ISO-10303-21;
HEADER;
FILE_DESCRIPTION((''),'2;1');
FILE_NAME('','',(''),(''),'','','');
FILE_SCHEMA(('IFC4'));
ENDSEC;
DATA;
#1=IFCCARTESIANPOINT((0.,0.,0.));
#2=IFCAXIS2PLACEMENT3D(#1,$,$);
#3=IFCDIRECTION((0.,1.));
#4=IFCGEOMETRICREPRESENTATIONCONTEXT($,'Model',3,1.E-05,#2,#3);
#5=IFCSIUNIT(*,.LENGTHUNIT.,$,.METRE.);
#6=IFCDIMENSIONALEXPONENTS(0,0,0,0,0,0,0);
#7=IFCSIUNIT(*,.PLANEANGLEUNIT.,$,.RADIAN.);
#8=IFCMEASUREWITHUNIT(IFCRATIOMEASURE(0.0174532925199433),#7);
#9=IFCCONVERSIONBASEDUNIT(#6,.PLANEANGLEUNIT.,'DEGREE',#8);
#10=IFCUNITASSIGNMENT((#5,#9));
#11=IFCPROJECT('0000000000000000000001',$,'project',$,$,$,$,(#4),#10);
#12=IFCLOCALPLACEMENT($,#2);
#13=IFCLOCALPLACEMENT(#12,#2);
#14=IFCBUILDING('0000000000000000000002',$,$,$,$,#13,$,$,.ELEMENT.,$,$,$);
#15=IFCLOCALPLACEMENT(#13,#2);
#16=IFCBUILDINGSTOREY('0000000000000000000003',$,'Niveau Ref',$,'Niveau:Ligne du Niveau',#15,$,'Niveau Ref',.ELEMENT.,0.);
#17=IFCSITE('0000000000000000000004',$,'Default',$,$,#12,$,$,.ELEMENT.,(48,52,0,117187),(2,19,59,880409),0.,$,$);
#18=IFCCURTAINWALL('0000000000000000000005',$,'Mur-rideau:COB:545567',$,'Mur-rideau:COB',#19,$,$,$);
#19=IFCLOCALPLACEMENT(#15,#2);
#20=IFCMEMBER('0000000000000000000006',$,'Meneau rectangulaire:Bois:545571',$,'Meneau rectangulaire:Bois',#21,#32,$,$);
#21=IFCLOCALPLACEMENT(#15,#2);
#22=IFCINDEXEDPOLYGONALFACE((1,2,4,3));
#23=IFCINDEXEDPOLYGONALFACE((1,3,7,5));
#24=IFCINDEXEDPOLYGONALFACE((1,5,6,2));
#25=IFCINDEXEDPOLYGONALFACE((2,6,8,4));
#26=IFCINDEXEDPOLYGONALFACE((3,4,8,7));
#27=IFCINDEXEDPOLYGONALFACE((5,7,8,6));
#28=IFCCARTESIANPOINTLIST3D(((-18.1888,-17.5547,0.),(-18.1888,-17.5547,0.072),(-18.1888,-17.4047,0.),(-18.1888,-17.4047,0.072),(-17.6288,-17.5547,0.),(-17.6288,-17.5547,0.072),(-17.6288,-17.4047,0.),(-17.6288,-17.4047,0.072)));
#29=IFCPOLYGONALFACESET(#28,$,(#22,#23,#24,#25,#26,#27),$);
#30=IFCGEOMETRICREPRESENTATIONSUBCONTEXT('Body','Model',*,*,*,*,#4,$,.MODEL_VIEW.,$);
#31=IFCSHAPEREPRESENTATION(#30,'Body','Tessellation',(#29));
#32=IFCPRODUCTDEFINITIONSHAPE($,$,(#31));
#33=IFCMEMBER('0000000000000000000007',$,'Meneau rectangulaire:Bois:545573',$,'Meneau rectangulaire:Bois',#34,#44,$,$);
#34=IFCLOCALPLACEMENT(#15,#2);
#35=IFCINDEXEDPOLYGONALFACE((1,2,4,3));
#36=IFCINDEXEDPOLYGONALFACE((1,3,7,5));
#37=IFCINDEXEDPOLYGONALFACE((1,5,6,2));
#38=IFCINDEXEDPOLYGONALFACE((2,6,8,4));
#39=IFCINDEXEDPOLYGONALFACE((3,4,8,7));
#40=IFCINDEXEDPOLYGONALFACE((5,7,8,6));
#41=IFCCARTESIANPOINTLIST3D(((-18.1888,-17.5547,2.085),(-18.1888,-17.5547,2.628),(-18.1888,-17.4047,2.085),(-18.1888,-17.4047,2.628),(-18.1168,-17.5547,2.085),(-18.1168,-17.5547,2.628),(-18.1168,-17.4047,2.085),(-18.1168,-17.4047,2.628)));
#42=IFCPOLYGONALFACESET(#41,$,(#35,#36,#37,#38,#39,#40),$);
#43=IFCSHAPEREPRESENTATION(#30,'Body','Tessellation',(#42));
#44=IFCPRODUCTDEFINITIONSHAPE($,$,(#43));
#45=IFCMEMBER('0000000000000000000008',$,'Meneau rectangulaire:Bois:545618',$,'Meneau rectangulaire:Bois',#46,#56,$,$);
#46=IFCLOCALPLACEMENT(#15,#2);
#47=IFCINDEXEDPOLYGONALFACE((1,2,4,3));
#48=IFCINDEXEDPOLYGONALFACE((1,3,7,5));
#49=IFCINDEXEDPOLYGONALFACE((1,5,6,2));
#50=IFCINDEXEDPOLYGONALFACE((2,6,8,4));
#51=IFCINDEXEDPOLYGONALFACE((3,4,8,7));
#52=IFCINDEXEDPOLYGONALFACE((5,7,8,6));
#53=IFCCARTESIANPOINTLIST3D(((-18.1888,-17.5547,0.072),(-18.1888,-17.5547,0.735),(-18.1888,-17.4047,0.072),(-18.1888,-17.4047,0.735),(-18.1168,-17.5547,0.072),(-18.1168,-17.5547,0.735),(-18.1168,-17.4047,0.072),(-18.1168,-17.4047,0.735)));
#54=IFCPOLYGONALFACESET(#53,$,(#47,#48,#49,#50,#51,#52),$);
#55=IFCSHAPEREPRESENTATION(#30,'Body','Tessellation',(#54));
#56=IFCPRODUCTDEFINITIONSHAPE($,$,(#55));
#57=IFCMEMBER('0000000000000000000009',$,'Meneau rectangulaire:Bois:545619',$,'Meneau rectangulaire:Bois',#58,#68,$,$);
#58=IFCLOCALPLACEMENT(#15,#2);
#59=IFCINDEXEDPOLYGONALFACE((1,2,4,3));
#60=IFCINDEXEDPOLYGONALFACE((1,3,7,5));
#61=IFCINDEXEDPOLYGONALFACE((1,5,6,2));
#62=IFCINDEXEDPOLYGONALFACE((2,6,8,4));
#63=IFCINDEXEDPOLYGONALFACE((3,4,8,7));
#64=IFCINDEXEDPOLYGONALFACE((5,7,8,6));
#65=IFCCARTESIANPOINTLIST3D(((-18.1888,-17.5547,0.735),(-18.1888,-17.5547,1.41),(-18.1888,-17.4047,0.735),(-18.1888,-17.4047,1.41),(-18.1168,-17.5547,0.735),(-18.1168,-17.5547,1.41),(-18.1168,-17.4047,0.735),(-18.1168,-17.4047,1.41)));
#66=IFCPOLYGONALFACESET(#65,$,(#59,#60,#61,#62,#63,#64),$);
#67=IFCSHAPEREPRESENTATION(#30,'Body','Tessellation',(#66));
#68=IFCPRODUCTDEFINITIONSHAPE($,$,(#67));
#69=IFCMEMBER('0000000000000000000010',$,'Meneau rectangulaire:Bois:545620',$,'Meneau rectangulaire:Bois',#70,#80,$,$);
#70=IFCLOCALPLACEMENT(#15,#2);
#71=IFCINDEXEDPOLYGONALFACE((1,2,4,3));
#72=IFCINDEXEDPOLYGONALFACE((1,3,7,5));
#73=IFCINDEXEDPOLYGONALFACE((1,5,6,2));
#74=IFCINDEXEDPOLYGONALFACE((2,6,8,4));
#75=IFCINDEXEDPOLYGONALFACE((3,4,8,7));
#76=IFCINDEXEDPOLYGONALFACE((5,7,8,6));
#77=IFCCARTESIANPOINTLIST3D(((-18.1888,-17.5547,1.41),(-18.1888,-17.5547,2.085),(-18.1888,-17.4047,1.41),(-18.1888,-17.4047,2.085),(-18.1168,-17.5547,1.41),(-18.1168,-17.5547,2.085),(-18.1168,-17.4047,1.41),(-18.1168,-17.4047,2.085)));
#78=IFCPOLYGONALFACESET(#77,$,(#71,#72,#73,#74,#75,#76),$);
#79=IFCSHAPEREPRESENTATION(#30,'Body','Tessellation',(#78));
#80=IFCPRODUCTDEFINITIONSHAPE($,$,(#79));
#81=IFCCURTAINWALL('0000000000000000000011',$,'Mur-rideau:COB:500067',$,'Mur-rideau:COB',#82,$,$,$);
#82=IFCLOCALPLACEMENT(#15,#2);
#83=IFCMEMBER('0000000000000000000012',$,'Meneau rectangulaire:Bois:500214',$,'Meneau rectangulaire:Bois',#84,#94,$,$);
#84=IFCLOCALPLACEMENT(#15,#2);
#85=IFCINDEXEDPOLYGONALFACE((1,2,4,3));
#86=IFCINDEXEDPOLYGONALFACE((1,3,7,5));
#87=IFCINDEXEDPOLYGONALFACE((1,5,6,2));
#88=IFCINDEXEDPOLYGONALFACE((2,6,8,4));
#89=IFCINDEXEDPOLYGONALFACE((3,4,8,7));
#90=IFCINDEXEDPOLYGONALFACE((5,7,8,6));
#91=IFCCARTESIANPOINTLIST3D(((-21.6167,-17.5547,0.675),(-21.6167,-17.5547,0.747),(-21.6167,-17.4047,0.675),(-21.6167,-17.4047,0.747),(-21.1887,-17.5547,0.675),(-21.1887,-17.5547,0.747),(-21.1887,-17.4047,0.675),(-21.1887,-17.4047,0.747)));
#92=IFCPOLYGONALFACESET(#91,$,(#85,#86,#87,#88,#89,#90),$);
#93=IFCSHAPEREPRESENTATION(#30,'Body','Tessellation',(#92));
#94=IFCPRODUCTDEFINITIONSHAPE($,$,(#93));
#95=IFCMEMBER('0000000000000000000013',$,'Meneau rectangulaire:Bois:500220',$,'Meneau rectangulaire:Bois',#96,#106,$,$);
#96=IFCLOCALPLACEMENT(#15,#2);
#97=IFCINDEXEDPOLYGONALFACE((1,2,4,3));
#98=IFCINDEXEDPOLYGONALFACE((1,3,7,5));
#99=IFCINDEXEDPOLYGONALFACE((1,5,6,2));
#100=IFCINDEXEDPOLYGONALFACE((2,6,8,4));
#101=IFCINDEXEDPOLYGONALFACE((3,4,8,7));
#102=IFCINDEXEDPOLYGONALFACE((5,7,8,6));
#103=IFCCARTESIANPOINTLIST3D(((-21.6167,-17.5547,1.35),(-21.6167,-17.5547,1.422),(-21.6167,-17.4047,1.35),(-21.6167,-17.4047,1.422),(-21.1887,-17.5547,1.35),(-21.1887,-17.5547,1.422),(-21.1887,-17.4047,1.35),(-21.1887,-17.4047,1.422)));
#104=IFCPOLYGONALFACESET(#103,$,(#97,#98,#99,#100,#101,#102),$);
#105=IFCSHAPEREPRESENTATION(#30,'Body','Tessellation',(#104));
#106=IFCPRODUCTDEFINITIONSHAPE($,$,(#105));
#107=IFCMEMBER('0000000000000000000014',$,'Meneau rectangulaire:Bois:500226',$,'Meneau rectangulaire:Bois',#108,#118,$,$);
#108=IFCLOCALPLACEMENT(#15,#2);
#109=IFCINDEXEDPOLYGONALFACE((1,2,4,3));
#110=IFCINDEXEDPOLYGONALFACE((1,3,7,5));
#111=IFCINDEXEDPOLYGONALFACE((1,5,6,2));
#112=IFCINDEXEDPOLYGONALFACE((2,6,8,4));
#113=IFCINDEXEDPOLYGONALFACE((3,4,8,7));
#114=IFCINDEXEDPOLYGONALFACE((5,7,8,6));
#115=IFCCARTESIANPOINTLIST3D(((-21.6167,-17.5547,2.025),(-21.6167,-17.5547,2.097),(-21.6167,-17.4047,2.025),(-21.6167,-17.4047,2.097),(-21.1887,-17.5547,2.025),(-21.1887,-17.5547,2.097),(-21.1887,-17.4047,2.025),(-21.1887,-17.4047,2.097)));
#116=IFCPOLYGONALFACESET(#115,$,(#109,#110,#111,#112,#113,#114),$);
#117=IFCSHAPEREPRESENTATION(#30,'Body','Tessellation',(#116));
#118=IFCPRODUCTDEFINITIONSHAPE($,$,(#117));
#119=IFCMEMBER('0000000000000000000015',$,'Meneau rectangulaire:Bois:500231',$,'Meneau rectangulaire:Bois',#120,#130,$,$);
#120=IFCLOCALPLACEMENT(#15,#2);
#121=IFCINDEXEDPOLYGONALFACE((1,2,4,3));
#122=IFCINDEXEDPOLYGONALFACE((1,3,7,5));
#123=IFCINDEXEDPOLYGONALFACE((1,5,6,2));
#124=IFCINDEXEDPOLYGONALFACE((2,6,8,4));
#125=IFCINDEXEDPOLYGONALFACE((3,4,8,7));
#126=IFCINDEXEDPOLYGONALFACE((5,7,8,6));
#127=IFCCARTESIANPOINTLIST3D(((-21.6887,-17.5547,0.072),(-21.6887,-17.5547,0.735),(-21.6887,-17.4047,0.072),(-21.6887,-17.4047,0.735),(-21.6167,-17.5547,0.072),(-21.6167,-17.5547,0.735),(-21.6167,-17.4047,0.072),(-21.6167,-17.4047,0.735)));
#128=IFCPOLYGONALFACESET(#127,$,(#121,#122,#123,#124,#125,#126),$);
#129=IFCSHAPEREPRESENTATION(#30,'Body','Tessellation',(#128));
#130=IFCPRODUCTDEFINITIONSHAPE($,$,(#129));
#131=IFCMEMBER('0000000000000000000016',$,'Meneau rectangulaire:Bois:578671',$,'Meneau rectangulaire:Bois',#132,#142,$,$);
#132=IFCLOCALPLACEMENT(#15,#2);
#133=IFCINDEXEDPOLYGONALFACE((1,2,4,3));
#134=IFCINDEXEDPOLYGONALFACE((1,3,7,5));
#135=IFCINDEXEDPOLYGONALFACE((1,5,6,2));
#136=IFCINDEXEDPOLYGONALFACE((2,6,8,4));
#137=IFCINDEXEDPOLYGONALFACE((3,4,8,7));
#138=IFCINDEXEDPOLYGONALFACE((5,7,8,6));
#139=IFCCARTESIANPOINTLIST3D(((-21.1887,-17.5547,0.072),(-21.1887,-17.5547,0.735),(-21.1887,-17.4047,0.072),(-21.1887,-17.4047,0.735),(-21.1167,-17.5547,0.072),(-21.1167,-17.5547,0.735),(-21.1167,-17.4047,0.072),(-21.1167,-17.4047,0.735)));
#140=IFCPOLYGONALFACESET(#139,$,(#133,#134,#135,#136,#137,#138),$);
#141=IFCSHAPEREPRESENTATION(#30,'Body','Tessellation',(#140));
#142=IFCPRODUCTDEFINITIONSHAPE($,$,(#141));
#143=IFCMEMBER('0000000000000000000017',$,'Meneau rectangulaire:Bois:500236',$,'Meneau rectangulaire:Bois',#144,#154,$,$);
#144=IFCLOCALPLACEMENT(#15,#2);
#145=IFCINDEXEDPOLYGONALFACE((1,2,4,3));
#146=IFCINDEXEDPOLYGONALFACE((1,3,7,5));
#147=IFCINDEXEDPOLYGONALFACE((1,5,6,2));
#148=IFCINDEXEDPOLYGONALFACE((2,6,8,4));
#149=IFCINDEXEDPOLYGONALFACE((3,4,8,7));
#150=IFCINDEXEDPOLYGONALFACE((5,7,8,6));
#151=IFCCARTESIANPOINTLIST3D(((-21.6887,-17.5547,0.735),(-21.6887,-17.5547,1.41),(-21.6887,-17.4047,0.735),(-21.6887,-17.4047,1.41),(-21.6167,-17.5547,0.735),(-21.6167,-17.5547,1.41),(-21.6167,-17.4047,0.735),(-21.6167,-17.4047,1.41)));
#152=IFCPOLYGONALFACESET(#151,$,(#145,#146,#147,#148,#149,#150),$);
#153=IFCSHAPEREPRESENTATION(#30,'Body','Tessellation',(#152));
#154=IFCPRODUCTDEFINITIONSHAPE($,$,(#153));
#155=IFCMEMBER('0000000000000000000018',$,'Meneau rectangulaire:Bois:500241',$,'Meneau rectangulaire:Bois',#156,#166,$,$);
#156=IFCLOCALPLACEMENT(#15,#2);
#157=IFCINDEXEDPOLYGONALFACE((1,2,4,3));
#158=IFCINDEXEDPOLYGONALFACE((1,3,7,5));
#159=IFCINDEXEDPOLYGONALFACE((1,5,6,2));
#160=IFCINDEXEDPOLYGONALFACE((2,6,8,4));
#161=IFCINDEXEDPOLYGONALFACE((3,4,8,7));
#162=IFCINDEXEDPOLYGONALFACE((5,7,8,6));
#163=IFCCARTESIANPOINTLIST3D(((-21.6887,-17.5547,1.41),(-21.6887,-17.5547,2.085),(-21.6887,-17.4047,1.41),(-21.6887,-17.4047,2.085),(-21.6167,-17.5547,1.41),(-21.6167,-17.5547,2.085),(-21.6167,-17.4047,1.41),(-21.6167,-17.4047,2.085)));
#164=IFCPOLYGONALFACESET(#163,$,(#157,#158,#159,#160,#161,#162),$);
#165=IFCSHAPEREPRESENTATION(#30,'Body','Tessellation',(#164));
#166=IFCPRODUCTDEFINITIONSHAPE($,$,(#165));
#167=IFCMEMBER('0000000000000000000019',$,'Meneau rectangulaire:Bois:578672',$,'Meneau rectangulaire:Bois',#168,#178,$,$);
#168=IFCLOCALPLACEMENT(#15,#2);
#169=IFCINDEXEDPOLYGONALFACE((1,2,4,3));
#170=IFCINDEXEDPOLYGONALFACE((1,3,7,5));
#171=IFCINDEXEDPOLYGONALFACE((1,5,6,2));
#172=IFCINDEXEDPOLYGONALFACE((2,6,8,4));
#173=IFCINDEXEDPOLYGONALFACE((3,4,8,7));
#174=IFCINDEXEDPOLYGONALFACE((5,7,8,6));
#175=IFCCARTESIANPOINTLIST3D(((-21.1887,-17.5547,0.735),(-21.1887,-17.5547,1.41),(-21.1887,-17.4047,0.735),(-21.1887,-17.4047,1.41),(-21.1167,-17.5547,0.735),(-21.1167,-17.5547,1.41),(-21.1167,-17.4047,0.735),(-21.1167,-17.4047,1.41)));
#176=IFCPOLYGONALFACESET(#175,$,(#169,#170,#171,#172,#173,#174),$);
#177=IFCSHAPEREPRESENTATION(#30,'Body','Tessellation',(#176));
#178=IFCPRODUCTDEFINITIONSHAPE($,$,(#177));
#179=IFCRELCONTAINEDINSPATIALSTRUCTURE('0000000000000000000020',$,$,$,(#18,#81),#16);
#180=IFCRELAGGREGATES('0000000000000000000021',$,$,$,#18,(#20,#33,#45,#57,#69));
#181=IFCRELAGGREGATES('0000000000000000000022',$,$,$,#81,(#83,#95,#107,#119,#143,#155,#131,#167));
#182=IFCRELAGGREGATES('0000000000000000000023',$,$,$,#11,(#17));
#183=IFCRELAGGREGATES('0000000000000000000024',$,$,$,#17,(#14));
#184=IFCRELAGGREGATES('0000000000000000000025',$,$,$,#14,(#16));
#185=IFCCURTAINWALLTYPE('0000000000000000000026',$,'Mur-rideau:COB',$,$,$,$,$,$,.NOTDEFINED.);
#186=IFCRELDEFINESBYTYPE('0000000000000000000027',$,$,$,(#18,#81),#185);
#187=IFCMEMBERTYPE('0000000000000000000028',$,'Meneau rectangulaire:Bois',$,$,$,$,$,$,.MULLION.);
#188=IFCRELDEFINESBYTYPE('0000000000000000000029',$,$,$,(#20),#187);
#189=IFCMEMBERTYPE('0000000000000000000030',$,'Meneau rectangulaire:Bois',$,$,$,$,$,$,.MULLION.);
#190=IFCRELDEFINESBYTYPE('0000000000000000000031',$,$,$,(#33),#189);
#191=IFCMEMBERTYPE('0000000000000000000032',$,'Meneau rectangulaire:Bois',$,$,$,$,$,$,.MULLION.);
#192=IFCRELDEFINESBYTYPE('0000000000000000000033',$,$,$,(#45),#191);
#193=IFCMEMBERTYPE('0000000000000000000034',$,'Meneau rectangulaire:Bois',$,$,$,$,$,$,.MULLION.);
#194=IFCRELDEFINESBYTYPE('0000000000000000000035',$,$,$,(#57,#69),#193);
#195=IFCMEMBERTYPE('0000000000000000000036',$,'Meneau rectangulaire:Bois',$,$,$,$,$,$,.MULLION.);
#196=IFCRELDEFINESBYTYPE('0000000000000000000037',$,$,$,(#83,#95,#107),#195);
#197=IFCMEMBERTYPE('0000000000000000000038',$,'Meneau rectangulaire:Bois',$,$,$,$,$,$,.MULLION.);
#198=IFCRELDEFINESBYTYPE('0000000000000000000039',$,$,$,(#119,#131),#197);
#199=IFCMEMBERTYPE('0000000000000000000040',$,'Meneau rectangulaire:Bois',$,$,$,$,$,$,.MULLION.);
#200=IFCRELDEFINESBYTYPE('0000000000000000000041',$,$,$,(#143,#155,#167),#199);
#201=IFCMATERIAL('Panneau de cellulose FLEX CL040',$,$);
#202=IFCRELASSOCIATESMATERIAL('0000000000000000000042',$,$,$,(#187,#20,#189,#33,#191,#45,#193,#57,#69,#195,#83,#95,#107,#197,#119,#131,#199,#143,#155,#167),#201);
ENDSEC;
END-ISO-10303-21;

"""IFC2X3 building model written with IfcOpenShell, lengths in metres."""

from ifc_helpers import new_model, entity, si_unit, converted_unit, direction, frame, origin, origin_2d_with_axis, place, context, subcontext, project, spatial, rectangle, extrude, source, transform, mapped, material, type_object, type_shapes, element, aggregate, save


model = new_model("IFC2X3")

# Units and contexts
model_context = context("Model", 3, precision=1e-05, world=origin(), true_north=direction((0.0, 1.0)))
body_context = subcontext(model_context, "Body", "Model", "MODEL_VIEW")
ifc_project = project(units=[si_unit("LENGTHUNIT", "METRE"), converted_unit("PLANEANGLEUNIT", "DEGREE", entity("IfcRatioMeasure", 0.0174532925199433), si_unit("PLANEANGLEUNIT", "RADIAN"), dimensions=[0, 0, 0, 0, 0, 0, 0])], contexts=[model_context])

# Site, building, storey
site_placement = place(None, origin())
site = spatial("IfcSite", under=ifc_project, at=site_placement, Name="Default", CompositionType="ELEMENT", RefLatitude=(48, 52, 0, 117187), RefLongitude=(2, 19, 59, 880409), RefElevation=0.0)
building_placement = place(site_placement, origin())
building = spatial("IfcBuilding", under=site, at=building_placement, CompositionType="ELEMENT")
storey_placement = place(building_placement, origin())
storey = spatial("IfcBuildingStorey", under=building, at=storey_placement, Name="Niveau Ref", ObjectType="Niveau:Ligne du Niveau", LongName="Niveau Ref", CompositionType="ELEMENT", Elevation=0.0)

# Curtain walls, members
curtain_wall_type_1 = type_object("IfcCurtainWallType", Name="Mur-rideau:COB", PredefinedType="NOTDEFINED")
curtain_wall_1_placement = place(storey_placement, origin())
curtain_wall_1 = element("IfcCurtainWall", 1, at=curtain_wall_1_placement, inside=storey, type_object=curtain_wall_type_1, Name="Mur-rideau:COB:545567", ObjectType="Mur-rideau:COB")
ifc_material_1 = material(Name="Panneau de cellulose FLEX CL040")
member_type_1 = type_object("IfcMemberType", Name="Meneau rectangulaire:Bois", PredefinedType="MULLION", material=ifc_material_1)
shared_shape_1 = source(origin(), body_context, "Body", "SweptSolid", [
    extrude(rectangle(XDim=0.15, YDim=0.072, at=origin_2d_with_axis()), frame((-0.036, 0.0, -0.56), z_axis=(0.0, 0.0, 1.0), x_axis=(0.0, -1.0, 0.0)), (0.0, 0.0, 1.0), 0.56),
])
type_shapes(member_type_1, [shared_shape_1])
member_1_placement = place(storey_placement, frame((-18.1888, -17.4797, 0.0), z_axis=(-1.0, 0.0, 0.0), x_axis=(0.0, 0.0, -1.0)))
member_1 = element("IfcMember", 2, at=member_1_placement, type_object=member_type_1, material=ifc_material_1, Name="Meneau rectangulaire:Bois:545571", ObjectType="Meneau rectangulaire:Bois", context=body_context, shape_type="MappedRepresentation", body=[
    mapped(shared_shape_1, transform((0.0, 0.0, 0.0), scale=1.0)),
])
member_type_2 = type_object("IfcMemberType", Name="Meneau rectangulaire:Bois", PredefinedType="MULLION", material=ifc_material_1)
shared_shape_2 = source(origin(), body_context, "Body", "SweptSolid", [
    extrude(rectangle(XDim=0.15, YDim=0.072, at=origin_2d_with_axis()), frame((-0.036, 0.0, -0.543), z_axis=(0.0, 0.0, 1.0), x_axis=(0.0, -1.0, 0.0)), (0.0, 0.0, 1.0), 0.543),
])
type_shapes(member_type_2, [shared_shape_2])
member_2_placement = place(storey_placement, frame((-18.1888, -17.4797, 2.628), z_axis=(0.0, 0.0, 1.0), x_axis=(-1.0, 0.0, 0.0)))
member_2 = element("IfcMember", 3, at=member_2_placement, type_object=member_type_2, material=ifc_material_1, Name="Meneau rectangulaire:Bois:545573", ObjectType="Meneau rectangulaire:Bois", context=body_context, shape_type="MappedRepresentation", body=[
    mapped(shared_shape_2, transform((0.0, 0.0, 0.0), scale=1.0)),
])
member_type_3 = type_object("IfcMemberType", Name="Meneau rectangulaire:Bois", PredefinedType="MULLION", material=ifc_material_1)
shared_shape_3 = source(origin(), body_context, "Body", "SweptSolid", [
    extrude(rectangle(XDim=0.15, YDim=0.072, at=origin_2d_with_axis()), frame((-0.036, 0.0, -0.663), z_axis=(0.0, 0.0, 1.0), x_axis=(0.0, -1.0, 0.0)), (0.0, 0.0, 1.0), 0.663),
])
type_shapes(member_type_3, [shared_shape_3])
member_3_placement = place(storey_placement, frame((-18.1888, -17.4797, 0.735), z_axis=(0.0, 0.0, 1.0), x_axis=(-1.0, 0.0, 0.0)))
member_3 = element("IfcMember", 4, at=member_3_placement, type_object=member_type_3, material=ifc_material_1, Name="Meneau rectangulaire:Bois:545618", ObjectType="Meneau rectangulaire:Bois", context=body_context, shape_type="MappedRepresentation", body=[
    mapped(shared_shape_3, transform((0.0, 0.0, 0.0), scale=1.0)),
])
member_type_4 = type_object("IfcMemberType", Name="Meneau rectangulaire:Bois", PredefinedType="MULLION", material=ifc_material_1)
shared_shape_4 = source(origin(), body_context, "Body", "SweptSolid", [
    extrude(rectangle(XDim=0.15, YDim=0.072, at=origin_2d_with_axis()), frame((-0.036, 0.0, -0.675), z_axis=(0.0, 0.0, 1.0), x_axis=(0.0, -1.0, 0.0)), (0.0, 0.0, 1.0), 0.675),
])
type_shapes(member_type_4, [shared_shape_4])
member_4_placement = place(storey_placement, frame((-18.1888, -17.4797, 1.41), z_axis=(0.0, 0.0, 1.0), x_axis=(-1.0, 0.0, 0.0)))
member_4 = element("IfcMember", 5, at=member_4_placement, type_object=member_type_4, material=ifc_material_1, Name="Meneau rectangulaire:Bois:545619", ObjectType="Meneau rectangulaire:Bois", context=body_context, shape_type="MappedRepresentation", body=[
    mapped(shared_shape_4, transform((0.0, 0.0, 0.0), scale=1.0)),
])
member_5_placement = place(storey_placement, frame((-18.1888, -17.4797, 2.085), z_axis=(0.0, 0.0, 1.0), x_axis=(-1.0, 0.0, 0.0)))
member_5 = element("IfcMember", 6, at=member_5_placement, type_object=member_type_4, material=ifc_material_1, Name="Meneau rectangulaire:Bois:545620", ObjectType="Meneau rectangulaire:Bois", context=body_context, shape_type="MappedRepresentation", body=[
    mapped(shared_shape_4, transform((0.0, 0.0, 0.0), scale=1.0)),
])
aggregate(curtain_wall_1, [member_1, member_2, member_3, member_4, member_5])
curtain_wall_2_placement = place(storey_placement, origin())
curtain_wall_2 = element("IfcCurtainWall", 7, at=curtain_wall_2_placement, inside=storey, type_object=curtain_wall_type_1, Name="Mur-rideau:COB:500067", ObjectType="Mur-rideau:COB")
member_type_5 = type_object("IfcMemberType", Name="Meneau rectangulaire:Bois", PredefinedType="MULLION", material=ifc_material_1)
shared_shape_5 = source(origin(), body_context, "Body", "SweptSolid", [
    extrude(rectangle(XDim=0.15, YDim=0.072, at=origin_2d_with_axis()), frame((-0.024, 0.0, -0.428), z_axis=(0.0, 0.0, 1.0), x_axis=(0.0, -1.0, 0.0)), (0.0, 0.0, 1.0), 0.428),
])
type_shapes(member_type_5, [shared_shape_5])
member_6_placement = place(storey_placement, frame((-21.1887, -17.4797, 0.735), z_axis=(1.0, 0.0, 0.0), x_axis=(0.0, 0.0, 1.0)))
member_6 = element("IfcMember", 8, at=member_6_placement, type_object=member_type_5, material=ifc_material_1, Name="Meneau rectangulaire:Bois:500214", ObjectType="Meneau rectangulaire:Bois", context=body_context, shape_type="MappedRepresentation", body=[
    mapped(shared_shape_5, transform((0.0, 0.0, 0.0), scale=1.0)),
])
member_7_placement = place(storey_placement, frame((-21.1887, -17.4797, 1.41), z_axis=(1.0, 0.0, 0.0), x_axis=(0.0, 0.0, 1.0)))
member_7 = element("IfcMember", 9, at=member_7_placement, type_object=member_type_5, material=ifc_material_1, Name="Meneau rectangulaire:Bois:500220", ObjectType="Meneau rectangulaire:Bois", context=body_context, shape_type="MappedRepresentation", body=[
    mapped(shared_shape_5, transform((0.0, 0.0, 0.0), scale=1.0)),
])
member_8_placement = place(storey_placement, frame((-21.1887, -17.4797, 2.085), z_axis=(1.0, 0.0, 0.0), x_axis=(0.0, 0.0, 1.0)))
member_8 = element("IfcMember", 10, at=member_8_placement, type_object=member_type_5, material=ifc_material_1, Name="Meneau rectangulaire:Bois:500226", ObjectType="Meneau rectangulaire:Bois", context=body_context, shape_type="MappedRepresentation", body=[
    mapped(shared_shape_5, transform((0.0, 0.0, 0.0), scale=1.0)),
])
member_type_6 = type_object("IfcMemberType", Name="Meneau rectangulaire:Bois", PredefinedType="MULLION", material=ifc_material_1)
shared_shape_6 = source(origin(), body_context, "Body", "SweptSolid", [
    extrude(rectangle(XDim=0.15, YDim=0.072, at=origin_2d_with_axis()), frame((-0.024, 0.0, -0.663), z_axis=(0.0, 0.0, 1.0), x_axis=(0.0, -1.0, 0.0)), (0.0, 0.0, 1.0), 0.663),
])
type_shapes(member_type_6, [shared_shape_6])
member_9_placement = place(storey_placement, frame((-21.6287, -17.4797, 0.072), z_axis=(0.0, 0.0, -1.0), x_axis=(1.0, 0.0, 0.0)))
member_9 = element("IfcMember", 11, at=member_9_placement, type_object=member_type_6, material=ifc_material_1, Name="Meneau rectangulaire:Bois:500231", ObjectType="Meneau rectangulaire:Bois", context=body_context, shape_type="MappedRepresentation", body=[
    mapped(shared_shape_6, transform((0.0, 0.0, 0.0), scale=1.0)),
])
member_10_placement = place(storey_placement, frame((-21.1287, -17.4797, 0.072), z_axis=(0.0, 0.0, -1.0), x_axis=(1.0, 0.0, 0.0)))
member_10 = element("IfcMember", 12, at=member_10_placement, type_object=member_type_6, material=ifc_material_1, Name="Meneau rectangulaire:Bois:578671", ObjectType="Meneau rectangulaire:Bois", context=body_context, shape_type="MappedRepresentation", body=[
    mapped(shared_shape_6, transform((0.0, 0.0, 0.0), scale=1.0)),
])
member_type_7 = type_object("IfcMemberType", Name="Meneau rectangulaire:Bois", PredefinedType="MULLION", material=ifc_material_1)
shared_shape_7 = source(origin(), body_context, "Body", "SweptSolid", [
    extrude(rectangle(XDim=0.15, YDim=0.072, at=origin_2d_with_axis()), frame((-0.024, 0.0, -0.675), z_axis=(0.0, 0.0, 1.0), x_axis=(0.0, -1.0, 0.0)), (0.0, 0.0, 1.0), 0.675),
])
type_shapes(member_type_7, [shared_shape_7])
member_11_placement = place(storey_placement, frame((-21.6287, -17.4797, 0.735), z_axis=(0.0, 0.0, -1.0), x_axis=(1.0, 0.0, 0.0)))
member_11 = element("IfcMember", 13, at=member_11_placement, type_object=member_type_7, material=ifc_material_1, Name="Meneau rectangulaire:Bois:500236", ObjectType="Meneau rectangulaire:Bois", context=body_context, shape_type="MappedRepresentation", body=[
    mapped(shared_shape_7, transform((0.0, 0.0, 0.0), scale=1.0)),
])
member_12_placement = place(storey_placement, frame((-21.6287, -17.4797, 1.41), z_axis=(0.0, 0.0, -1.0), x_axis=(1.0, 0.0, 0.0)))
member_12 = element("IfcMember", 14, at=member_12_placement, type_object=member_type_7, material=ifc_material_1, Name="Meneau rectangulaire:Bois:500241", ObjectType="Meneau rectangulaire:Bois", context=body_context, shape_type="MappedRepresentation", body=[
    mapped(shared_shape_7, transform((0.0, 0.0, 0.0), scale=1.0)),
])
member_13_placement = place(storey_placement, frame((-21.1287, -17.4797, 0.735), z_axis=(0.0, 0.0, -1.0), x_axis=(1.0, 0.0, 0.0)))
member_13 = element("IfcMember", 15, at=member_13_placement, type_object=member_type_7, material=ifc_material_1, Name="Meneau rectangulaire:Bois:578672", ObjectType="Meneau rectangulaire:Bois", context=body_context, shape_type="MappedRepresentation", body=[
    mapped(shared_shape_7, transform((0.0, 0.0, 0.0), scale=1.0)),
])
aggregate(curtain_wall_2, [member_6, member_7, member_8, member_9, member_11, member_12, member_10, member_13])

save(model, "model.ifc")
